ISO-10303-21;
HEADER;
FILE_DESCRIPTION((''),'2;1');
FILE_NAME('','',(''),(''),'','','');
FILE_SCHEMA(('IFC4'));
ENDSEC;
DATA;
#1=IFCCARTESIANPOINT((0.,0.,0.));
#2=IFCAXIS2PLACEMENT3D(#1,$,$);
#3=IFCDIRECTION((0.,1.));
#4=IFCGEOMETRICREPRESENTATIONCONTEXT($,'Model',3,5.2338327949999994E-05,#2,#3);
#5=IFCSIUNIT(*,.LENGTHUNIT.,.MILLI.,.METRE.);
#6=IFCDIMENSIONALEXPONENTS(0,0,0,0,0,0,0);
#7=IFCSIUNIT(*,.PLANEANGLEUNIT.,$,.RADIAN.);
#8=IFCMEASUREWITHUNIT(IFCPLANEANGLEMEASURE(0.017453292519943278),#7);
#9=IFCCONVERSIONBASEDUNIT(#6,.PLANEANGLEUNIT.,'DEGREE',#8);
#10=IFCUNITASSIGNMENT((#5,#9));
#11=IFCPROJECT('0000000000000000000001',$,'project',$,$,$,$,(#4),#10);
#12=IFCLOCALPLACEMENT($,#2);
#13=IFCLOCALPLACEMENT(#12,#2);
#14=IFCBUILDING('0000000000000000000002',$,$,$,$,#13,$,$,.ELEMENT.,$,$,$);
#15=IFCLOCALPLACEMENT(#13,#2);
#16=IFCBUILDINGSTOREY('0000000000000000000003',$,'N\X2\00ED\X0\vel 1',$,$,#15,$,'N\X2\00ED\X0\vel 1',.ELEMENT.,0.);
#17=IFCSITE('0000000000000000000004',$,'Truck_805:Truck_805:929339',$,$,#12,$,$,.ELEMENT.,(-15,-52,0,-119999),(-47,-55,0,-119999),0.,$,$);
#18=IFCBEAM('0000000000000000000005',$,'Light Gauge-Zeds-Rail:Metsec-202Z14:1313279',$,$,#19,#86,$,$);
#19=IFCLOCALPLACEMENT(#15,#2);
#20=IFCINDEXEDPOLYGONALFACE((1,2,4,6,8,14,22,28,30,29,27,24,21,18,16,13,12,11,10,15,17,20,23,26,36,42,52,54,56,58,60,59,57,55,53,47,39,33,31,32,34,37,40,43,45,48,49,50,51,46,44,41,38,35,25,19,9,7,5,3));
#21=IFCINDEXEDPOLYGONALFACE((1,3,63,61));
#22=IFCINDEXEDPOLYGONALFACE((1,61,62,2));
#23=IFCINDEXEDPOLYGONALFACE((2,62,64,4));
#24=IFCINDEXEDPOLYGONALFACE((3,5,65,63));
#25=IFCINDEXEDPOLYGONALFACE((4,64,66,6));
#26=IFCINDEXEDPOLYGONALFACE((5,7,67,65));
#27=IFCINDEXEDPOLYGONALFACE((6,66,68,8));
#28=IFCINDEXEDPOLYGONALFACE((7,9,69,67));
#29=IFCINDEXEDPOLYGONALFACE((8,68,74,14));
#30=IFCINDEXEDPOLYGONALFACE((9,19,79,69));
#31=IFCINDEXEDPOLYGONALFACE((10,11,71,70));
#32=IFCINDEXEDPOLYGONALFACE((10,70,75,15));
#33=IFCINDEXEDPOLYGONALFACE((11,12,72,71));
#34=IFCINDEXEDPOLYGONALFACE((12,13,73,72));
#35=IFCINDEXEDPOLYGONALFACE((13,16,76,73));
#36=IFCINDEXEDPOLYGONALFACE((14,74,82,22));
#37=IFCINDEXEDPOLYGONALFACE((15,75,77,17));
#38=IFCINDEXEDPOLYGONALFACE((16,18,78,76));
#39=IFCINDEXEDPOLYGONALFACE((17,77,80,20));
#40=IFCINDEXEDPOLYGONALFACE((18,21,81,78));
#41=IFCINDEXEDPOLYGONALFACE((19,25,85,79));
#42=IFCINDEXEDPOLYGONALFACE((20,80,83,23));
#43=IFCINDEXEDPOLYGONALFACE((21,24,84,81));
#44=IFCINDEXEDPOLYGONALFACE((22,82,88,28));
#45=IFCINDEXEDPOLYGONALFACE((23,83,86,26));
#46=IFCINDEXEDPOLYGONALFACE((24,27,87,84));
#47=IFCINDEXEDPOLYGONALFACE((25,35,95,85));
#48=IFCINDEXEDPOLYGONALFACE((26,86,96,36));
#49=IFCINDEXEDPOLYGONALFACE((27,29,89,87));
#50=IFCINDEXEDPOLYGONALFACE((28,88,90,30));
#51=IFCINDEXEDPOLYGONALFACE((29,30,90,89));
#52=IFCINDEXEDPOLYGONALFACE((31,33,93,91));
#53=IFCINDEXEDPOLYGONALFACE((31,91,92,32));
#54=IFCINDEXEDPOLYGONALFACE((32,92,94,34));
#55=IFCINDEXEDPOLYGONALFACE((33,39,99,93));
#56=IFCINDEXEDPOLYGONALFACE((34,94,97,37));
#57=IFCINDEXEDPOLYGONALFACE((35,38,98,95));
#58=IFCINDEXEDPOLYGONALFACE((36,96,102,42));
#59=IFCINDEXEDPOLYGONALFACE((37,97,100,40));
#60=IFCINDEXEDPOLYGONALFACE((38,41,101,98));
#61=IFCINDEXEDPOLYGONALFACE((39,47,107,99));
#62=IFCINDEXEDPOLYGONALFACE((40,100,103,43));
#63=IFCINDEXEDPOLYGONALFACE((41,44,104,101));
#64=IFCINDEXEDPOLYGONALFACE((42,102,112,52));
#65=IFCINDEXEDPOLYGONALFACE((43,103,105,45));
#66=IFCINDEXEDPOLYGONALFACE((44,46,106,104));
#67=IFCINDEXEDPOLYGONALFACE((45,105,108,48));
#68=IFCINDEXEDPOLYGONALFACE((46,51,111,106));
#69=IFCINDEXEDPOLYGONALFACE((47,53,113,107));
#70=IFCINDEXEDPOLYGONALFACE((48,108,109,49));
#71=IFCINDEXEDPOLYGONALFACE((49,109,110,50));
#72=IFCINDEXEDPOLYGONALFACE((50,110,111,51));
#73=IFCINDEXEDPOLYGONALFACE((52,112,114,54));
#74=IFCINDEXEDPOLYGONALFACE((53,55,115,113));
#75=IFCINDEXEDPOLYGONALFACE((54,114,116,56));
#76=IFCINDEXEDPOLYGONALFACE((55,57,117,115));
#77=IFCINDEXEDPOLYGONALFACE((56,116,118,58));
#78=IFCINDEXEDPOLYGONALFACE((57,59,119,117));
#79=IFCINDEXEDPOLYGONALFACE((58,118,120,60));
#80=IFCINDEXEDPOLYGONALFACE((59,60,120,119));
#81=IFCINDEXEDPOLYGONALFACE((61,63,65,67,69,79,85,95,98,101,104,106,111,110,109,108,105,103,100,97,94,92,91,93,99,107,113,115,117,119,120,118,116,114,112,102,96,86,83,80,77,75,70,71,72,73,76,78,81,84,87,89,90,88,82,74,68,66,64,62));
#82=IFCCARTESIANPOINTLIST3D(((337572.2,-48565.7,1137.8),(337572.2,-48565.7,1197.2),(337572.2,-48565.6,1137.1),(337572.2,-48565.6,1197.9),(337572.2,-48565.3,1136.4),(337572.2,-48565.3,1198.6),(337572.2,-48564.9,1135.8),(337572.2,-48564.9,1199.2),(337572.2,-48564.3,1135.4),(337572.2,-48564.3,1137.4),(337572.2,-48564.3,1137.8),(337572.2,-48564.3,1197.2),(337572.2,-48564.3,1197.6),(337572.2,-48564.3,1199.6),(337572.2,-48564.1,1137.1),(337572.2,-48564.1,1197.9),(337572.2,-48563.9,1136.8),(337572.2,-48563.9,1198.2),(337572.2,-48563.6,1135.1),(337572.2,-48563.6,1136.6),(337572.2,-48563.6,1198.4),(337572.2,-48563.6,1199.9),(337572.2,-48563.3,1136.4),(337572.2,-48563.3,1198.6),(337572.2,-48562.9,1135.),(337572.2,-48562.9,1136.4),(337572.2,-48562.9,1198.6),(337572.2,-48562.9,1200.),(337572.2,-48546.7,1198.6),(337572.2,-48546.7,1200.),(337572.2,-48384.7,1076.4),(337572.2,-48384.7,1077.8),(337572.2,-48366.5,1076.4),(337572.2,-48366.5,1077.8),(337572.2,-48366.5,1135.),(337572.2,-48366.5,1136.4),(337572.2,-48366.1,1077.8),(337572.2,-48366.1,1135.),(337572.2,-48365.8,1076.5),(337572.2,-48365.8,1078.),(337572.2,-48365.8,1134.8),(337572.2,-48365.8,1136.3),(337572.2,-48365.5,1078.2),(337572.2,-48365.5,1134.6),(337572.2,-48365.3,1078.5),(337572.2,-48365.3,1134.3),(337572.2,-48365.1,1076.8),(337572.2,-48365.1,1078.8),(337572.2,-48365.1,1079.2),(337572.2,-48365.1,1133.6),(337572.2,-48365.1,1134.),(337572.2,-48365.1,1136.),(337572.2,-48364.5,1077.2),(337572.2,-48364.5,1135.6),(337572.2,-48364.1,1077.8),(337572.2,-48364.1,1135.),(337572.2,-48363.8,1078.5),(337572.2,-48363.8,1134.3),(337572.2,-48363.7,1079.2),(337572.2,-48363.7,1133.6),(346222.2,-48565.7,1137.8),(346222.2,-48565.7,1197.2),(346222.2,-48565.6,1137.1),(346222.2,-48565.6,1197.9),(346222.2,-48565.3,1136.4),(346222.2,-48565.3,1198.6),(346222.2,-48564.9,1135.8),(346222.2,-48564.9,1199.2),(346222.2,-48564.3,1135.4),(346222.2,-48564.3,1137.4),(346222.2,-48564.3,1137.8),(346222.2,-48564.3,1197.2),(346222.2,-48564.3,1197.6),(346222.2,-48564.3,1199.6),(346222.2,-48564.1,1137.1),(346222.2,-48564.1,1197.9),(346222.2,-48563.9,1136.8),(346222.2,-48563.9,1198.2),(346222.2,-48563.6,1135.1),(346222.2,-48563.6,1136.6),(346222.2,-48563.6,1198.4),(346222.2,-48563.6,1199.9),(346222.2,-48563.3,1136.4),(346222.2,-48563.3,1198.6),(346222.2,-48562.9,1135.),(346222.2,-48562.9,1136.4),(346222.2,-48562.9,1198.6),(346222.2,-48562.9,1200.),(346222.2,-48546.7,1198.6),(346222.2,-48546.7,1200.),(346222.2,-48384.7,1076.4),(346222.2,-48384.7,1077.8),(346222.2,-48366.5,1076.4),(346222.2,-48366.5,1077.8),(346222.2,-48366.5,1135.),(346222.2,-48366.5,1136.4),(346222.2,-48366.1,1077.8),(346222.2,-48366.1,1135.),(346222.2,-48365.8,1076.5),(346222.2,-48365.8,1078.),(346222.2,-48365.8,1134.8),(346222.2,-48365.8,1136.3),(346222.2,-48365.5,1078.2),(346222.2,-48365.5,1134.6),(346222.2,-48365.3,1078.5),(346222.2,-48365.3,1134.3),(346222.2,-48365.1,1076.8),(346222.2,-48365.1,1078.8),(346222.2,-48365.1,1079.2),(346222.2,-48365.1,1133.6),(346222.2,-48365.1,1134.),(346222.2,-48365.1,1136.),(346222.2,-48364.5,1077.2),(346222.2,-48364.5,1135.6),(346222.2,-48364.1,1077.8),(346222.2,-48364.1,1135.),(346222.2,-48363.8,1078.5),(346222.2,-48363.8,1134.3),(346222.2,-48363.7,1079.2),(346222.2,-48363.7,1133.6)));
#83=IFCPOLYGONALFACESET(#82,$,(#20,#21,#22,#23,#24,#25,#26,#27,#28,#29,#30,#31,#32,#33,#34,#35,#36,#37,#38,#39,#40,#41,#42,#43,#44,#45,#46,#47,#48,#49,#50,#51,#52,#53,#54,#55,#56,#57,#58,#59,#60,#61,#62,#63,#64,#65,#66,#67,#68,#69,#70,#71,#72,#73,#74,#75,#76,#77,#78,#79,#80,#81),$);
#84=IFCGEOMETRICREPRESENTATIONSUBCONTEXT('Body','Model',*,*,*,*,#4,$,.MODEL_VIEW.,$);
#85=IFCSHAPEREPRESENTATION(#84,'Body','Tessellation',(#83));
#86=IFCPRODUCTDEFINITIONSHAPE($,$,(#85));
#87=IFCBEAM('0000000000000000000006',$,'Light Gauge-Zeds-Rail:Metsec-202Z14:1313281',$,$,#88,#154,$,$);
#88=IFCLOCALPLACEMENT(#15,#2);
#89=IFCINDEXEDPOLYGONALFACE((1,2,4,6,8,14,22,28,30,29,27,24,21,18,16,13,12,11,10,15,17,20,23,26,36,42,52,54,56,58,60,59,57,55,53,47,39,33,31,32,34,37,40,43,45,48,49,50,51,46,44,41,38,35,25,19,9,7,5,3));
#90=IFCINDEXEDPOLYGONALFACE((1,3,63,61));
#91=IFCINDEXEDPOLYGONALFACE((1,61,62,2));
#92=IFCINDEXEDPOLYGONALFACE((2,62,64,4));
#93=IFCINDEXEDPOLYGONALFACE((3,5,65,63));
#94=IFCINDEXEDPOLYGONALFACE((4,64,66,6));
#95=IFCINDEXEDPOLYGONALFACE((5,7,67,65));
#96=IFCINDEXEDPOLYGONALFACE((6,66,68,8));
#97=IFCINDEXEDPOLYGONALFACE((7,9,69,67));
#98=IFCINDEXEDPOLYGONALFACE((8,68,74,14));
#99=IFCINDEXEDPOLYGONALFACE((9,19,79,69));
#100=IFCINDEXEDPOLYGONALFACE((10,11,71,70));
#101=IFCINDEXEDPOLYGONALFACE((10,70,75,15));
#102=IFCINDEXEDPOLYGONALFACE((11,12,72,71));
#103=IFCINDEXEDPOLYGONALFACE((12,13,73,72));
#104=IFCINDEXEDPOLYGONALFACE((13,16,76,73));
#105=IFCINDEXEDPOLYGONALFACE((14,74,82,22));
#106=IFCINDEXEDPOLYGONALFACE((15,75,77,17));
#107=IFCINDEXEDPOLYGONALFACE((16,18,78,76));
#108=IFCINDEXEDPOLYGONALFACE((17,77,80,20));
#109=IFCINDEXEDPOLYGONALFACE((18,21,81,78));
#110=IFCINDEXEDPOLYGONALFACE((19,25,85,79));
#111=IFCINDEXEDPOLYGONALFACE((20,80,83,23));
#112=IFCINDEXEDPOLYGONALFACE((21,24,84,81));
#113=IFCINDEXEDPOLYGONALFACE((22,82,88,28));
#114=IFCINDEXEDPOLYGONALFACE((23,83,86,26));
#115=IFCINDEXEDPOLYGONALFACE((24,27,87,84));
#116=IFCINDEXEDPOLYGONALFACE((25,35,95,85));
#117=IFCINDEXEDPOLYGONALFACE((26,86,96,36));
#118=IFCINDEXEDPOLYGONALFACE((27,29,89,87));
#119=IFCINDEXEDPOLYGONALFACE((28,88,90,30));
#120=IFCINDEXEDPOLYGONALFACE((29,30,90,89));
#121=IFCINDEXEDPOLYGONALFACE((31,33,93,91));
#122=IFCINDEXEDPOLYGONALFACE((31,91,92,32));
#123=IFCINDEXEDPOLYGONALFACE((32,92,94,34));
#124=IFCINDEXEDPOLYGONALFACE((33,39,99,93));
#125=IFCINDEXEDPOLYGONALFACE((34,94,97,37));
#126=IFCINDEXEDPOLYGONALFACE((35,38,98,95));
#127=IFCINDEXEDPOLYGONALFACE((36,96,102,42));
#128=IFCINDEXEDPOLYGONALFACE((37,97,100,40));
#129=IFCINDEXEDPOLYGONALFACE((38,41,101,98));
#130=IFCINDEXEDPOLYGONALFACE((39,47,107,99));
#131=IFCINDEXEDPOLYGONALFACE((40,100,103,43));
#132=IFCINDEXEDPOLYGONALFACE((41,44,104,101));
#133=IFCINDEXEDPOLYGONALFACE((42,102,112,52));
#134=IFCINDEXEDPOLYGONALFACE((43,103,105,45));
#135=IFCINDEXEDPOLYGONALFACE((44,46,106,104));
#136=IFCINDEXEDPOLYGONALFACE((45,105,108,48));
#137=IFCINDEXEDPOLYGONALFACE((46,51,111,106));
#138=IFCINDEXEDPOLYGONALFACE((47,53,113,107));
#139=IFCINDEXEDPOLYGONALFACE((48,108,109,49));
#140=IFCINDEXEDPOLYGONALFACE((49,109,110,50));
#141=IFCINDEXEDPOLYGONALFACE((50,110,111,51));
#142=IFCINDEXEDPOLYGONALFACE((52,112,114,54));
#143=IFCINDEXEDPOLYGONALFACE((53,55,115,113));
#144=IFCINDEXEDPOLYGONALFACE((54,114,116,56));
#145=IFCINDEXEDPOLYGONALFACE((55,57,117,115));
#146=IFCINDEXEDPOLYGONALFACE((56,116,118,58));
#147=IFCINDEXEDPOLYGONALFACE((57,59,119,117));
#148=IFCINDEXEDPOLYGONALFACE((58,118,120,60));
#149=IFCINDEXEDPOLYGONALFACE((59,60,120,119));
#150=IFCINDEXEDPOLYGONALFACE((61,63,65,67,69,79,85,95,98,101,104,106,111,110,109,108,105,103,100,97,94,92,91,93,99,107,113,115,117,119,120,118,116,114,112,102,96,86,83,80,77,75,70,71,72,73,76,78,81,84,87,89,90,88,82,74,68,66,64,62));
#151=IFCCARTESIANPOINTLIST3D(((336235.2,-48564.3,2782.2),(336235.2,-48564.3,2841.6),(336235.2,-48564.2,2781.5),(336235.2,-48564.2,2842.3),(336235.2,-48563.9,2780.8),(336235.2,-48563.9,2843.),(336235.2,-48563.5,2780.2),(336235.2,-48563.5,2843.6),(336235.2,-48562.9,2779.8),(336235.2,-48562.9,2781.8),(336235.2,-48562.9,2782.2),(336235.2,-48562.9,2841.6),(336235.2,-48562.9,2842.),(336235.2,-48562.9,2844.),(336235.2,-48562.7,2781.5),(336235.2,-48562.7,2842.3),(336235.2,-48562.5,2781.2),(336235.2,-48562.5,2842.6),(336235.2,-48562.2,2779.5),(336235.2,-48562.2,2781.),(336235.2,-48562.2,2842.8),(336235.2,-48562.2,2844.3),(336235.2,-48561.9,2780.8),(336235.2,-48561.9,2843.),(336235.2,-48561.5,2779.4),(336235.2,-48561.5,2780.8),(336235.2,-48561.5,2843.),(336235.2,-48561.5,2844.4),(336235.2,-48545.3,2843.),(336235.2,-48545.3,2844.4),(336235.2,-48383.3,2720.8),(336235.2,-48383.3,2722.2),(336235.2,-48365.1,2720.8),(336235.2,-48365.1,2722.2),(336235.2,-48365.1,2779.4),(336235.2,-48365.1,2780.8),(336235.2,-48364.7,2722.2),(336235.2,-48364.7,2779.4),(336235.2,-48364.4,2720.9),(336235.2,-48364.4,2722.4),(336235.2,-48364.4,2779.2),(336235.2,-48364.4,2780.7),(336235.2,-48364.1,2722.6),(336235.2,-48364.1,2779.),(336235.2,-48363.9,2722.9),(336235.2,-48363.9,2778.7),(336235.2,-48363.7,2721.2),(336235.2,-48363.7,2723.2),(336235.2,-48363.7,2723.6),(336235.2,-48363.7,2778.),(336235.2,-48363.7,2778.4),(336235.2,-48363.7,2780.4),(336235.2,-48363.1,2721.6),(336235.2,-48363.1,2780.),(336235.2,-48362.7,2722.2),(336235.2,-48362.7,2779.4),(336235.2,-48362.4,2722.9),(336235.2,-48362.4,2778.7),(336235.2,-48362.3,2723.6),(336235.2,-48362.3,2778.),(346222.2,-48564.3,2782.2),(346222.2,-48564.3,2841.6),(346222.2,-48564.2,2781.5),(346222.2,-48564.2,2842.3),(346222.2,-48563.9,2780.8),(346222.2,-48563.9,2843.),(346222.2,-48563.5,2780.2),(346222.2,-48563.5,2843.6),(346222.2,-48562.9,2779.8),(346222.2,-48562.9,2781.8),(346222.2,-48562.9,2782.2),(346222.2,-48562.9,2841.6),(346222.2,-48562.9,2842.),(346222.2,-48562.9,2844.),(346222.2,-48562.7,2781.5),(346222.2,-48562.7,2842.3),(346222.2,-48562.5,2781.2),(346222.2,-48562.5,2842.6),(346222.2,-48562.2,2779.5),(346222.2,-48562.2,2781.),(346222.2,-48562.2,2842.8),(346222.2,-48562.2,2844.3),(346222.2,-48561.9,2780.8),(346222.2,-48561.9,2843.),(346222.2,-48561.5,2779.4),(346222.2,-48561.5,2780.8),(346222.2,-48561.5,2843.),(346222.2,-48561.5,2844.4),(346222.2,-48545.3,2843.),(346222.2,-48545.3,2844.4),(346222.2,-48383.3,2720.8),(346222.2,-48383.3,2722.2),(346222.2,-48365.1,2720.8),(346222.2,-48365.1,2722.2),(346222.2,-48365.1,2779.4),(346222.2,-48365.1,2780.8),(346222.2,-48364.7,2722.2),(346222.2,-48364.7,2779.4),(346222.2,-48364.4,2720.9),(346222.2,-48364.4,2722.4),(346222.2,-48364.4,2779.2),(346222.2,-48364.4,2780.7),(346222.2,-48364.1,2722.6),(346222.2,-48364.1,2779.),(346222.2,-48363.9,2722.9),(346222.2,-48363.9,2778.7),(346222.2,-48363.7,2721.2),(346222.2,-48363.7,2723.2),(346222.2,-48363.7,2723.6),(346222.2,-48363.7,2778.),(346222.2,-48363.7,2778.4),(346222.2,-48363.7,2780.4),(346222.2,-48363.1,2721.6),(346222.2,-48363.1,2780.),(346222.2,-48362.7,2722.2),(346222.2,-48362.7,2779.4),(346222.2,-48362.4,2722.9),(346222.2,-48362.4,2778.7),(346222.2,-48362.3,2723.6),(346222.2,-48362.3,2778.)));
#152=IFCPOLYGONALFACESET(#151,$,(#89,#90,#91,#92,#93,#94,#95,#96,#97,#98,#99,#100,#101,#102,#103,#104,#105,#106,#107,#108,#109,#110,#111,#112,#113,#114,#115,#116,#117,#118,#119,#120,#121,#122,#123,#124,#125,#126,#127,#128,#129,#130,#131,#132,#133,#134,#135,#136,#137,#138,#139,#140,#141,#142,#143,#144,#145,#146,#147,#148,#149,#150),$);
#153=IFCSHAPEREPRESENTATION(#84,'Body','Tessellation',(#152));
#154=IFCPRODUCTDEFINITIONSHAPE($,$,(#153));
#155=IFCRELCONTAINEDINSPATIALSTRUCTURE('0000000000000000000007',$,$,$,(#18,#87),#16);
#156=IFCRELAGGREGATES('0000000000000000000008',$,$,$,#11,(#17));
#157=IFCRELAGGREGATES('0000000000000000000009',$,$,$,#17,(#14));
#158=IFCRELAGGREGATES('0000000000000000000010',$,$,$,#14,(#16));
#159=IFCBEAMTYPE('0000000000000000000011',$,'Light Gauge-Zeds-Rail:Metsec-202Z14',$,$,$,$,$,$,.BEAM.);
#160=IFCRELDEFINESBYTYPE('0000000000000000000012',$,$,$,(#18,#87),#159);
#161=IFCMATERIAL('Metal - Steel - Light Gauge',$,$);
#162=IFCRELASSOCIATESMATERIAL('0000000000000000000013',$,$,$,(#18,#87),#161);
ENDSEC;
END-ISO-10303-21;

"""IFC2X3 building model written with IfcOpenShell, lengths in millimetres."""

from ifc_helpers import new_model, entity, si_unit, converted_unit, direction, frame, frame_2d, origin, place, context, subcontext, project, spatial, polyline, circle_curve, parameter, trimmed, segment, composite_curve, outline, extrude, material, type_object, element, save


model = new_model("IFC2X3")

# Units and contexts
model_context = context("Model", 3, precision=5.2338327949999994e-05, world=origin(), true_north=direction((0.0, 1.0)))
body_context = subcontext(model_context, "Body", "Model", "MODEL_VIEW")
ifc_project = project(units=[si_unit("LENGTHUNIT", "METRE", prefix="MILLI"), converted_unit("PLANEANGLEUNIT", "DEGREE", entity("IfcPlaneAngleMeasure", 0.017453292519943278), si_unit("PLANEANGLEUNIT", "RADIAN"), dimensions=[0, 0, 0, 0, 0, 0, 0])], contexts=[model_context])

# Site, building, storey
site_placement = place(None, origin())
site = spatial("IfcSite", under=ifc_project, at=site_placement, Name="Truck_805:Truck_805:929339", CompositionType="ELEMENT", RefLatitude=(-15, -52, 0, -119999), RefLongitude=(-47, -55, 0, -119999), RefElevation=0.0)
building_placement = place(site_placement, origin())
building = spatial("IfcBuilding", under=site, at=building_placement, CompositionType="ELEMENT")
storey_placement = place(building_placement, origin())
storey = spatial("IfcBuildingStorey", under=building, at=storey_placement, Name="Nível 1", LongName="Nível 1", CompositionType="ELEMENT", Elevation=0.0)

# Beams
ifc_material_1 = material(Name="Metal - Steel - Light Gauge")
beam_type_1 = type_object("IfcBeamType", Name="Light Gauge-Zeds-Rail:Metsec-202Z14", PredefinedType="BEAM")
beam_1_placement = place(storey_placement, frame((337572.2, -48465.6, 1200.0)))
element("IfcBeam", 1, at=beam_1_placement, inside=storey, type_object=beam_type_1, material=ifc_material_1, Name="Light Gauge-Zeds-Rail:Metsec-202Z14:1313279", context=body_context, shape_type="SweptSolid", body=[
    extrude(outline(composite_curve([segment(polyline([(-60.0, -100.8), (-0.6, -100.8)]), True, "CONTINUOUS"), segment(trimmed(circle_curve(frame_2d((-0.6, -98.0), x_axis=(0.0, -1.0)), 2.8), [parameter(0.0)], [parameter(90.0)], True, "PARAMETER"), True, "CONTINUOUS"), segment(polyline([(2.2, -98.0), (2.2, 98.4)]), True, "CONTINUOUS"), segment(trimmed(circle_curve(frame_2d((3.6, 98.4), x_axis=(-1.0, 0.0)), 1.4), [parameter(270.0)], [parameter(0.0)], True, "PARAMETER"), False, "CONTINUOUS"), segment(polyline([(3.6, 99.8), (58.0, 99.8)]), True, "CONTINUOUS"), segment(trimmed(circle_curve(frame_2d((58.0, 98.4), x_axis=(0.0, 1.0)), 1.4), [parameter(270.0)], [parameter(0.0)], True, "PARAMETER"), False, "CONTINUOUS"), segment(polyline([(59.4, 98.4), (59.4, 80.2)]), True, "CONTINUOUS"), segment(polyline([(59.4, 80.2), (60.8, 80.2)]), True, "CONTINUOUS"), segment(polyline([(60.8, 80.2), (60.8, 98.4)]), True, "CONTINUOUS"), segment(trimmed(circle_curve(frame_2d((58.0, 98.4), x_axis=(1.0, 0.0)), 2.8), [parameter(0.0)], [parameter(90.0)], True, "PARAMETER"), True, "CONTINUOUS"), segment(polyline([(58.0, 101.2), (3.6, 101.2)]), True, "CONTINUOUS"), segment(trimmed(circle_curve(frame_2d((3.6, 98.4), x_axis=(0.0, 1.0)), 2.8), [parameter(0.0)], [parameter(90.0)], True, "PARAMETER"), True, "CONTINUOUS"), segment(polyline([(0.8, 98.4), (0.8, -98.0)]), True, "CONTINUOUS"), segment(trimmed(circle_curve(frame_2d((-0.6, -98.0), x_axis=(1.0, 0.0)), 1.4), [parameter(270.0)], [parameter(0.0)], True, "PARAMETER"), False, "CONTINUOUS"), segment(polyline([(-0.6, -99.4), (-60.0, -99.4)]), True, "CONTINUOUS"), segment(trimmed(circle_curve(frame_2d((-60.0, -98.0), x_axis=(0.0, -1.0)), 1.4), [parameter(270.0)], [parameter(0.0)], True, "PARAMETER"), False, "CONTINUOUS"), segment(polyline([(-61.4, -98.0), (-61.4, -81.8)]), True, "CONTINUOUS"), segment(polyline([(-61.4, -81.8), (-62.8, -81.8)]), True, "CONTINUOUS"), segment(polyline([(-62.8, -81.8), (-62.8, -98.0)]), True, "CONTINUOUS"), segment(trimmed(circle_curve(frame_2d((-60.0, -98.0), x_axis=(-1.0, 0.0)), 2.8), [parameter(0.0)], [parameter(90.0)], True, "PARAMETER"), True, "CONTINUOUS")], self_intersect=False)), frame((0.0, 0.7, -62.8), z_axis=(1.0, 0.0, 0.0), x_axis=(0.0, 0.0, -1.0)), (0.0, 0.0, 1.0), 8650.0),
])
beam_2_placement = place(storey_placement, frame((336222.2, -48464.2, 2844.4)))
element("IfcBeam", 2, at=beam_2_placement, inside=storey, type_object=beam_type_1, material=ifc_material_1, Name="Light Gauge-Zeds-Rail:Metsec-202Z14:1313281", context=body_context, shape_type="SweptSolid", body=[
    extrude(outline(composite_curve([segment(polyline([(-60.0, -100.8), (-0.6, -100.8)]), True, "CONTINUOUS"), segment(trimmed(circle_curve(frame_2d((-0.6, -98.0), x_axis=(0.0, -1.0)), 2.8), [parameter(0.0)], [parameter(90.0)], True, "PARAMETER"), True, "CONTINUOUS"), segment(polyline([(2.2, -98.0), (2.2, 98.4)]), True, "CONTINUOUS"), segment(trimmed(circle_curve(frame_2d((3.6, 98.4), x_axis=(-1.0, 0.0)), 1.4), [parameter(270.0)], [parameter(0.0)], True, "PARAMETER"), False, "CONTINUOUS"), segment(polyline([(3.6, 99.8), (58.0, 99.8)]), True, "CONTINUOUS"), segment(trimmed(circle_curve(frame_2d((58.0, 98.4), x_axis=(0.0, 1.0)), 1.4), [parameter(270.0)], [parameter(0.0)], True, "PARAMETER"), False, "CONTINUOUS"), segment(polyline([(59.4, 98.4), (59.4, 80.2)]), True, "CONTINUOUS"), segment(polyline([(59.4, 80.2), (60.8, 80.2)]), True, "CONTINUOUS"), segment(polyline([(60.8, 80.2), (60.8, 98.4)]), True, "CONTINUOUS"), segment(trimmed(circle_curve(frame_2d((58.0, 98.4), x_axis=(1.0, 0.0)), 2.8), [parameter(0.0)], [parameter(90.0)], True, "PARAMETER"), True, "CONTINUOUS"), segment(polyline([(58.0, 101.2), (3.6, 101.2)]), True, "CONTINUOUS"), segment(trimmed(circle_curve(frame_2d((3.6, 98.4), x_axis=(0.0, 1.0)), 2.8), [parameter(0.0)], [parameter(90.0)], True, "PARAMETER"), True, "CONTINUOUS"), segment(polyline([(0.8, 98.4), (0.8, -98.0)]), True, "CONTINUOUS"), segment(trimmed(circle_curve(frame_2d((-0.6, -98.0), x_axis=(1.0, 0.0)), 1.4), [parameter(270.0)], [parameter(0.0)], True, "PARAMETER"), False, "CONTINUOUS"), segment(polyline([(-0.6, -99.4), (-60.0, -99.4)]), True, "CONTINUOUS"), segment(trimmed(circle_curve(frame_2d((-60.0, -98.0), x_axis=(0.0, -1.0)), 1.4), [parameter(270.0)], [parameter(0.0)], True, "PARAMETER"), False, "CONTINUOUS"), segment(polyline([(-61.4, -98.0), (-61.4, -81.8)]), True, "CONTINUOUS"), segment(polyline([(-61.4, -81.8), (-62.8, -81.8)]), True, "CONTINUOUS"), segment(polyline([(-62.8, -81.8), (-62.8, -98.0)]), True, "CONTINUOUS"), segment(trimmed(circle_curve(frame_2d((-60.0, -98.0), x_axis=(-1.0, 0.0)), 2.8), [parameter(0.0)], [parameter(90.0)], True, "PARAMETER"), True, "CONTINUOUS")], self_intersect=False)), frame((13.0, 0.7, -62.8), z_axis=(1.0, 0.0, 0.0), x_axis=(0.0, 0.0, -1.0)), (0.0, 0.0, 1.0), 9987.0),
])

save(model, "model.ifc")
